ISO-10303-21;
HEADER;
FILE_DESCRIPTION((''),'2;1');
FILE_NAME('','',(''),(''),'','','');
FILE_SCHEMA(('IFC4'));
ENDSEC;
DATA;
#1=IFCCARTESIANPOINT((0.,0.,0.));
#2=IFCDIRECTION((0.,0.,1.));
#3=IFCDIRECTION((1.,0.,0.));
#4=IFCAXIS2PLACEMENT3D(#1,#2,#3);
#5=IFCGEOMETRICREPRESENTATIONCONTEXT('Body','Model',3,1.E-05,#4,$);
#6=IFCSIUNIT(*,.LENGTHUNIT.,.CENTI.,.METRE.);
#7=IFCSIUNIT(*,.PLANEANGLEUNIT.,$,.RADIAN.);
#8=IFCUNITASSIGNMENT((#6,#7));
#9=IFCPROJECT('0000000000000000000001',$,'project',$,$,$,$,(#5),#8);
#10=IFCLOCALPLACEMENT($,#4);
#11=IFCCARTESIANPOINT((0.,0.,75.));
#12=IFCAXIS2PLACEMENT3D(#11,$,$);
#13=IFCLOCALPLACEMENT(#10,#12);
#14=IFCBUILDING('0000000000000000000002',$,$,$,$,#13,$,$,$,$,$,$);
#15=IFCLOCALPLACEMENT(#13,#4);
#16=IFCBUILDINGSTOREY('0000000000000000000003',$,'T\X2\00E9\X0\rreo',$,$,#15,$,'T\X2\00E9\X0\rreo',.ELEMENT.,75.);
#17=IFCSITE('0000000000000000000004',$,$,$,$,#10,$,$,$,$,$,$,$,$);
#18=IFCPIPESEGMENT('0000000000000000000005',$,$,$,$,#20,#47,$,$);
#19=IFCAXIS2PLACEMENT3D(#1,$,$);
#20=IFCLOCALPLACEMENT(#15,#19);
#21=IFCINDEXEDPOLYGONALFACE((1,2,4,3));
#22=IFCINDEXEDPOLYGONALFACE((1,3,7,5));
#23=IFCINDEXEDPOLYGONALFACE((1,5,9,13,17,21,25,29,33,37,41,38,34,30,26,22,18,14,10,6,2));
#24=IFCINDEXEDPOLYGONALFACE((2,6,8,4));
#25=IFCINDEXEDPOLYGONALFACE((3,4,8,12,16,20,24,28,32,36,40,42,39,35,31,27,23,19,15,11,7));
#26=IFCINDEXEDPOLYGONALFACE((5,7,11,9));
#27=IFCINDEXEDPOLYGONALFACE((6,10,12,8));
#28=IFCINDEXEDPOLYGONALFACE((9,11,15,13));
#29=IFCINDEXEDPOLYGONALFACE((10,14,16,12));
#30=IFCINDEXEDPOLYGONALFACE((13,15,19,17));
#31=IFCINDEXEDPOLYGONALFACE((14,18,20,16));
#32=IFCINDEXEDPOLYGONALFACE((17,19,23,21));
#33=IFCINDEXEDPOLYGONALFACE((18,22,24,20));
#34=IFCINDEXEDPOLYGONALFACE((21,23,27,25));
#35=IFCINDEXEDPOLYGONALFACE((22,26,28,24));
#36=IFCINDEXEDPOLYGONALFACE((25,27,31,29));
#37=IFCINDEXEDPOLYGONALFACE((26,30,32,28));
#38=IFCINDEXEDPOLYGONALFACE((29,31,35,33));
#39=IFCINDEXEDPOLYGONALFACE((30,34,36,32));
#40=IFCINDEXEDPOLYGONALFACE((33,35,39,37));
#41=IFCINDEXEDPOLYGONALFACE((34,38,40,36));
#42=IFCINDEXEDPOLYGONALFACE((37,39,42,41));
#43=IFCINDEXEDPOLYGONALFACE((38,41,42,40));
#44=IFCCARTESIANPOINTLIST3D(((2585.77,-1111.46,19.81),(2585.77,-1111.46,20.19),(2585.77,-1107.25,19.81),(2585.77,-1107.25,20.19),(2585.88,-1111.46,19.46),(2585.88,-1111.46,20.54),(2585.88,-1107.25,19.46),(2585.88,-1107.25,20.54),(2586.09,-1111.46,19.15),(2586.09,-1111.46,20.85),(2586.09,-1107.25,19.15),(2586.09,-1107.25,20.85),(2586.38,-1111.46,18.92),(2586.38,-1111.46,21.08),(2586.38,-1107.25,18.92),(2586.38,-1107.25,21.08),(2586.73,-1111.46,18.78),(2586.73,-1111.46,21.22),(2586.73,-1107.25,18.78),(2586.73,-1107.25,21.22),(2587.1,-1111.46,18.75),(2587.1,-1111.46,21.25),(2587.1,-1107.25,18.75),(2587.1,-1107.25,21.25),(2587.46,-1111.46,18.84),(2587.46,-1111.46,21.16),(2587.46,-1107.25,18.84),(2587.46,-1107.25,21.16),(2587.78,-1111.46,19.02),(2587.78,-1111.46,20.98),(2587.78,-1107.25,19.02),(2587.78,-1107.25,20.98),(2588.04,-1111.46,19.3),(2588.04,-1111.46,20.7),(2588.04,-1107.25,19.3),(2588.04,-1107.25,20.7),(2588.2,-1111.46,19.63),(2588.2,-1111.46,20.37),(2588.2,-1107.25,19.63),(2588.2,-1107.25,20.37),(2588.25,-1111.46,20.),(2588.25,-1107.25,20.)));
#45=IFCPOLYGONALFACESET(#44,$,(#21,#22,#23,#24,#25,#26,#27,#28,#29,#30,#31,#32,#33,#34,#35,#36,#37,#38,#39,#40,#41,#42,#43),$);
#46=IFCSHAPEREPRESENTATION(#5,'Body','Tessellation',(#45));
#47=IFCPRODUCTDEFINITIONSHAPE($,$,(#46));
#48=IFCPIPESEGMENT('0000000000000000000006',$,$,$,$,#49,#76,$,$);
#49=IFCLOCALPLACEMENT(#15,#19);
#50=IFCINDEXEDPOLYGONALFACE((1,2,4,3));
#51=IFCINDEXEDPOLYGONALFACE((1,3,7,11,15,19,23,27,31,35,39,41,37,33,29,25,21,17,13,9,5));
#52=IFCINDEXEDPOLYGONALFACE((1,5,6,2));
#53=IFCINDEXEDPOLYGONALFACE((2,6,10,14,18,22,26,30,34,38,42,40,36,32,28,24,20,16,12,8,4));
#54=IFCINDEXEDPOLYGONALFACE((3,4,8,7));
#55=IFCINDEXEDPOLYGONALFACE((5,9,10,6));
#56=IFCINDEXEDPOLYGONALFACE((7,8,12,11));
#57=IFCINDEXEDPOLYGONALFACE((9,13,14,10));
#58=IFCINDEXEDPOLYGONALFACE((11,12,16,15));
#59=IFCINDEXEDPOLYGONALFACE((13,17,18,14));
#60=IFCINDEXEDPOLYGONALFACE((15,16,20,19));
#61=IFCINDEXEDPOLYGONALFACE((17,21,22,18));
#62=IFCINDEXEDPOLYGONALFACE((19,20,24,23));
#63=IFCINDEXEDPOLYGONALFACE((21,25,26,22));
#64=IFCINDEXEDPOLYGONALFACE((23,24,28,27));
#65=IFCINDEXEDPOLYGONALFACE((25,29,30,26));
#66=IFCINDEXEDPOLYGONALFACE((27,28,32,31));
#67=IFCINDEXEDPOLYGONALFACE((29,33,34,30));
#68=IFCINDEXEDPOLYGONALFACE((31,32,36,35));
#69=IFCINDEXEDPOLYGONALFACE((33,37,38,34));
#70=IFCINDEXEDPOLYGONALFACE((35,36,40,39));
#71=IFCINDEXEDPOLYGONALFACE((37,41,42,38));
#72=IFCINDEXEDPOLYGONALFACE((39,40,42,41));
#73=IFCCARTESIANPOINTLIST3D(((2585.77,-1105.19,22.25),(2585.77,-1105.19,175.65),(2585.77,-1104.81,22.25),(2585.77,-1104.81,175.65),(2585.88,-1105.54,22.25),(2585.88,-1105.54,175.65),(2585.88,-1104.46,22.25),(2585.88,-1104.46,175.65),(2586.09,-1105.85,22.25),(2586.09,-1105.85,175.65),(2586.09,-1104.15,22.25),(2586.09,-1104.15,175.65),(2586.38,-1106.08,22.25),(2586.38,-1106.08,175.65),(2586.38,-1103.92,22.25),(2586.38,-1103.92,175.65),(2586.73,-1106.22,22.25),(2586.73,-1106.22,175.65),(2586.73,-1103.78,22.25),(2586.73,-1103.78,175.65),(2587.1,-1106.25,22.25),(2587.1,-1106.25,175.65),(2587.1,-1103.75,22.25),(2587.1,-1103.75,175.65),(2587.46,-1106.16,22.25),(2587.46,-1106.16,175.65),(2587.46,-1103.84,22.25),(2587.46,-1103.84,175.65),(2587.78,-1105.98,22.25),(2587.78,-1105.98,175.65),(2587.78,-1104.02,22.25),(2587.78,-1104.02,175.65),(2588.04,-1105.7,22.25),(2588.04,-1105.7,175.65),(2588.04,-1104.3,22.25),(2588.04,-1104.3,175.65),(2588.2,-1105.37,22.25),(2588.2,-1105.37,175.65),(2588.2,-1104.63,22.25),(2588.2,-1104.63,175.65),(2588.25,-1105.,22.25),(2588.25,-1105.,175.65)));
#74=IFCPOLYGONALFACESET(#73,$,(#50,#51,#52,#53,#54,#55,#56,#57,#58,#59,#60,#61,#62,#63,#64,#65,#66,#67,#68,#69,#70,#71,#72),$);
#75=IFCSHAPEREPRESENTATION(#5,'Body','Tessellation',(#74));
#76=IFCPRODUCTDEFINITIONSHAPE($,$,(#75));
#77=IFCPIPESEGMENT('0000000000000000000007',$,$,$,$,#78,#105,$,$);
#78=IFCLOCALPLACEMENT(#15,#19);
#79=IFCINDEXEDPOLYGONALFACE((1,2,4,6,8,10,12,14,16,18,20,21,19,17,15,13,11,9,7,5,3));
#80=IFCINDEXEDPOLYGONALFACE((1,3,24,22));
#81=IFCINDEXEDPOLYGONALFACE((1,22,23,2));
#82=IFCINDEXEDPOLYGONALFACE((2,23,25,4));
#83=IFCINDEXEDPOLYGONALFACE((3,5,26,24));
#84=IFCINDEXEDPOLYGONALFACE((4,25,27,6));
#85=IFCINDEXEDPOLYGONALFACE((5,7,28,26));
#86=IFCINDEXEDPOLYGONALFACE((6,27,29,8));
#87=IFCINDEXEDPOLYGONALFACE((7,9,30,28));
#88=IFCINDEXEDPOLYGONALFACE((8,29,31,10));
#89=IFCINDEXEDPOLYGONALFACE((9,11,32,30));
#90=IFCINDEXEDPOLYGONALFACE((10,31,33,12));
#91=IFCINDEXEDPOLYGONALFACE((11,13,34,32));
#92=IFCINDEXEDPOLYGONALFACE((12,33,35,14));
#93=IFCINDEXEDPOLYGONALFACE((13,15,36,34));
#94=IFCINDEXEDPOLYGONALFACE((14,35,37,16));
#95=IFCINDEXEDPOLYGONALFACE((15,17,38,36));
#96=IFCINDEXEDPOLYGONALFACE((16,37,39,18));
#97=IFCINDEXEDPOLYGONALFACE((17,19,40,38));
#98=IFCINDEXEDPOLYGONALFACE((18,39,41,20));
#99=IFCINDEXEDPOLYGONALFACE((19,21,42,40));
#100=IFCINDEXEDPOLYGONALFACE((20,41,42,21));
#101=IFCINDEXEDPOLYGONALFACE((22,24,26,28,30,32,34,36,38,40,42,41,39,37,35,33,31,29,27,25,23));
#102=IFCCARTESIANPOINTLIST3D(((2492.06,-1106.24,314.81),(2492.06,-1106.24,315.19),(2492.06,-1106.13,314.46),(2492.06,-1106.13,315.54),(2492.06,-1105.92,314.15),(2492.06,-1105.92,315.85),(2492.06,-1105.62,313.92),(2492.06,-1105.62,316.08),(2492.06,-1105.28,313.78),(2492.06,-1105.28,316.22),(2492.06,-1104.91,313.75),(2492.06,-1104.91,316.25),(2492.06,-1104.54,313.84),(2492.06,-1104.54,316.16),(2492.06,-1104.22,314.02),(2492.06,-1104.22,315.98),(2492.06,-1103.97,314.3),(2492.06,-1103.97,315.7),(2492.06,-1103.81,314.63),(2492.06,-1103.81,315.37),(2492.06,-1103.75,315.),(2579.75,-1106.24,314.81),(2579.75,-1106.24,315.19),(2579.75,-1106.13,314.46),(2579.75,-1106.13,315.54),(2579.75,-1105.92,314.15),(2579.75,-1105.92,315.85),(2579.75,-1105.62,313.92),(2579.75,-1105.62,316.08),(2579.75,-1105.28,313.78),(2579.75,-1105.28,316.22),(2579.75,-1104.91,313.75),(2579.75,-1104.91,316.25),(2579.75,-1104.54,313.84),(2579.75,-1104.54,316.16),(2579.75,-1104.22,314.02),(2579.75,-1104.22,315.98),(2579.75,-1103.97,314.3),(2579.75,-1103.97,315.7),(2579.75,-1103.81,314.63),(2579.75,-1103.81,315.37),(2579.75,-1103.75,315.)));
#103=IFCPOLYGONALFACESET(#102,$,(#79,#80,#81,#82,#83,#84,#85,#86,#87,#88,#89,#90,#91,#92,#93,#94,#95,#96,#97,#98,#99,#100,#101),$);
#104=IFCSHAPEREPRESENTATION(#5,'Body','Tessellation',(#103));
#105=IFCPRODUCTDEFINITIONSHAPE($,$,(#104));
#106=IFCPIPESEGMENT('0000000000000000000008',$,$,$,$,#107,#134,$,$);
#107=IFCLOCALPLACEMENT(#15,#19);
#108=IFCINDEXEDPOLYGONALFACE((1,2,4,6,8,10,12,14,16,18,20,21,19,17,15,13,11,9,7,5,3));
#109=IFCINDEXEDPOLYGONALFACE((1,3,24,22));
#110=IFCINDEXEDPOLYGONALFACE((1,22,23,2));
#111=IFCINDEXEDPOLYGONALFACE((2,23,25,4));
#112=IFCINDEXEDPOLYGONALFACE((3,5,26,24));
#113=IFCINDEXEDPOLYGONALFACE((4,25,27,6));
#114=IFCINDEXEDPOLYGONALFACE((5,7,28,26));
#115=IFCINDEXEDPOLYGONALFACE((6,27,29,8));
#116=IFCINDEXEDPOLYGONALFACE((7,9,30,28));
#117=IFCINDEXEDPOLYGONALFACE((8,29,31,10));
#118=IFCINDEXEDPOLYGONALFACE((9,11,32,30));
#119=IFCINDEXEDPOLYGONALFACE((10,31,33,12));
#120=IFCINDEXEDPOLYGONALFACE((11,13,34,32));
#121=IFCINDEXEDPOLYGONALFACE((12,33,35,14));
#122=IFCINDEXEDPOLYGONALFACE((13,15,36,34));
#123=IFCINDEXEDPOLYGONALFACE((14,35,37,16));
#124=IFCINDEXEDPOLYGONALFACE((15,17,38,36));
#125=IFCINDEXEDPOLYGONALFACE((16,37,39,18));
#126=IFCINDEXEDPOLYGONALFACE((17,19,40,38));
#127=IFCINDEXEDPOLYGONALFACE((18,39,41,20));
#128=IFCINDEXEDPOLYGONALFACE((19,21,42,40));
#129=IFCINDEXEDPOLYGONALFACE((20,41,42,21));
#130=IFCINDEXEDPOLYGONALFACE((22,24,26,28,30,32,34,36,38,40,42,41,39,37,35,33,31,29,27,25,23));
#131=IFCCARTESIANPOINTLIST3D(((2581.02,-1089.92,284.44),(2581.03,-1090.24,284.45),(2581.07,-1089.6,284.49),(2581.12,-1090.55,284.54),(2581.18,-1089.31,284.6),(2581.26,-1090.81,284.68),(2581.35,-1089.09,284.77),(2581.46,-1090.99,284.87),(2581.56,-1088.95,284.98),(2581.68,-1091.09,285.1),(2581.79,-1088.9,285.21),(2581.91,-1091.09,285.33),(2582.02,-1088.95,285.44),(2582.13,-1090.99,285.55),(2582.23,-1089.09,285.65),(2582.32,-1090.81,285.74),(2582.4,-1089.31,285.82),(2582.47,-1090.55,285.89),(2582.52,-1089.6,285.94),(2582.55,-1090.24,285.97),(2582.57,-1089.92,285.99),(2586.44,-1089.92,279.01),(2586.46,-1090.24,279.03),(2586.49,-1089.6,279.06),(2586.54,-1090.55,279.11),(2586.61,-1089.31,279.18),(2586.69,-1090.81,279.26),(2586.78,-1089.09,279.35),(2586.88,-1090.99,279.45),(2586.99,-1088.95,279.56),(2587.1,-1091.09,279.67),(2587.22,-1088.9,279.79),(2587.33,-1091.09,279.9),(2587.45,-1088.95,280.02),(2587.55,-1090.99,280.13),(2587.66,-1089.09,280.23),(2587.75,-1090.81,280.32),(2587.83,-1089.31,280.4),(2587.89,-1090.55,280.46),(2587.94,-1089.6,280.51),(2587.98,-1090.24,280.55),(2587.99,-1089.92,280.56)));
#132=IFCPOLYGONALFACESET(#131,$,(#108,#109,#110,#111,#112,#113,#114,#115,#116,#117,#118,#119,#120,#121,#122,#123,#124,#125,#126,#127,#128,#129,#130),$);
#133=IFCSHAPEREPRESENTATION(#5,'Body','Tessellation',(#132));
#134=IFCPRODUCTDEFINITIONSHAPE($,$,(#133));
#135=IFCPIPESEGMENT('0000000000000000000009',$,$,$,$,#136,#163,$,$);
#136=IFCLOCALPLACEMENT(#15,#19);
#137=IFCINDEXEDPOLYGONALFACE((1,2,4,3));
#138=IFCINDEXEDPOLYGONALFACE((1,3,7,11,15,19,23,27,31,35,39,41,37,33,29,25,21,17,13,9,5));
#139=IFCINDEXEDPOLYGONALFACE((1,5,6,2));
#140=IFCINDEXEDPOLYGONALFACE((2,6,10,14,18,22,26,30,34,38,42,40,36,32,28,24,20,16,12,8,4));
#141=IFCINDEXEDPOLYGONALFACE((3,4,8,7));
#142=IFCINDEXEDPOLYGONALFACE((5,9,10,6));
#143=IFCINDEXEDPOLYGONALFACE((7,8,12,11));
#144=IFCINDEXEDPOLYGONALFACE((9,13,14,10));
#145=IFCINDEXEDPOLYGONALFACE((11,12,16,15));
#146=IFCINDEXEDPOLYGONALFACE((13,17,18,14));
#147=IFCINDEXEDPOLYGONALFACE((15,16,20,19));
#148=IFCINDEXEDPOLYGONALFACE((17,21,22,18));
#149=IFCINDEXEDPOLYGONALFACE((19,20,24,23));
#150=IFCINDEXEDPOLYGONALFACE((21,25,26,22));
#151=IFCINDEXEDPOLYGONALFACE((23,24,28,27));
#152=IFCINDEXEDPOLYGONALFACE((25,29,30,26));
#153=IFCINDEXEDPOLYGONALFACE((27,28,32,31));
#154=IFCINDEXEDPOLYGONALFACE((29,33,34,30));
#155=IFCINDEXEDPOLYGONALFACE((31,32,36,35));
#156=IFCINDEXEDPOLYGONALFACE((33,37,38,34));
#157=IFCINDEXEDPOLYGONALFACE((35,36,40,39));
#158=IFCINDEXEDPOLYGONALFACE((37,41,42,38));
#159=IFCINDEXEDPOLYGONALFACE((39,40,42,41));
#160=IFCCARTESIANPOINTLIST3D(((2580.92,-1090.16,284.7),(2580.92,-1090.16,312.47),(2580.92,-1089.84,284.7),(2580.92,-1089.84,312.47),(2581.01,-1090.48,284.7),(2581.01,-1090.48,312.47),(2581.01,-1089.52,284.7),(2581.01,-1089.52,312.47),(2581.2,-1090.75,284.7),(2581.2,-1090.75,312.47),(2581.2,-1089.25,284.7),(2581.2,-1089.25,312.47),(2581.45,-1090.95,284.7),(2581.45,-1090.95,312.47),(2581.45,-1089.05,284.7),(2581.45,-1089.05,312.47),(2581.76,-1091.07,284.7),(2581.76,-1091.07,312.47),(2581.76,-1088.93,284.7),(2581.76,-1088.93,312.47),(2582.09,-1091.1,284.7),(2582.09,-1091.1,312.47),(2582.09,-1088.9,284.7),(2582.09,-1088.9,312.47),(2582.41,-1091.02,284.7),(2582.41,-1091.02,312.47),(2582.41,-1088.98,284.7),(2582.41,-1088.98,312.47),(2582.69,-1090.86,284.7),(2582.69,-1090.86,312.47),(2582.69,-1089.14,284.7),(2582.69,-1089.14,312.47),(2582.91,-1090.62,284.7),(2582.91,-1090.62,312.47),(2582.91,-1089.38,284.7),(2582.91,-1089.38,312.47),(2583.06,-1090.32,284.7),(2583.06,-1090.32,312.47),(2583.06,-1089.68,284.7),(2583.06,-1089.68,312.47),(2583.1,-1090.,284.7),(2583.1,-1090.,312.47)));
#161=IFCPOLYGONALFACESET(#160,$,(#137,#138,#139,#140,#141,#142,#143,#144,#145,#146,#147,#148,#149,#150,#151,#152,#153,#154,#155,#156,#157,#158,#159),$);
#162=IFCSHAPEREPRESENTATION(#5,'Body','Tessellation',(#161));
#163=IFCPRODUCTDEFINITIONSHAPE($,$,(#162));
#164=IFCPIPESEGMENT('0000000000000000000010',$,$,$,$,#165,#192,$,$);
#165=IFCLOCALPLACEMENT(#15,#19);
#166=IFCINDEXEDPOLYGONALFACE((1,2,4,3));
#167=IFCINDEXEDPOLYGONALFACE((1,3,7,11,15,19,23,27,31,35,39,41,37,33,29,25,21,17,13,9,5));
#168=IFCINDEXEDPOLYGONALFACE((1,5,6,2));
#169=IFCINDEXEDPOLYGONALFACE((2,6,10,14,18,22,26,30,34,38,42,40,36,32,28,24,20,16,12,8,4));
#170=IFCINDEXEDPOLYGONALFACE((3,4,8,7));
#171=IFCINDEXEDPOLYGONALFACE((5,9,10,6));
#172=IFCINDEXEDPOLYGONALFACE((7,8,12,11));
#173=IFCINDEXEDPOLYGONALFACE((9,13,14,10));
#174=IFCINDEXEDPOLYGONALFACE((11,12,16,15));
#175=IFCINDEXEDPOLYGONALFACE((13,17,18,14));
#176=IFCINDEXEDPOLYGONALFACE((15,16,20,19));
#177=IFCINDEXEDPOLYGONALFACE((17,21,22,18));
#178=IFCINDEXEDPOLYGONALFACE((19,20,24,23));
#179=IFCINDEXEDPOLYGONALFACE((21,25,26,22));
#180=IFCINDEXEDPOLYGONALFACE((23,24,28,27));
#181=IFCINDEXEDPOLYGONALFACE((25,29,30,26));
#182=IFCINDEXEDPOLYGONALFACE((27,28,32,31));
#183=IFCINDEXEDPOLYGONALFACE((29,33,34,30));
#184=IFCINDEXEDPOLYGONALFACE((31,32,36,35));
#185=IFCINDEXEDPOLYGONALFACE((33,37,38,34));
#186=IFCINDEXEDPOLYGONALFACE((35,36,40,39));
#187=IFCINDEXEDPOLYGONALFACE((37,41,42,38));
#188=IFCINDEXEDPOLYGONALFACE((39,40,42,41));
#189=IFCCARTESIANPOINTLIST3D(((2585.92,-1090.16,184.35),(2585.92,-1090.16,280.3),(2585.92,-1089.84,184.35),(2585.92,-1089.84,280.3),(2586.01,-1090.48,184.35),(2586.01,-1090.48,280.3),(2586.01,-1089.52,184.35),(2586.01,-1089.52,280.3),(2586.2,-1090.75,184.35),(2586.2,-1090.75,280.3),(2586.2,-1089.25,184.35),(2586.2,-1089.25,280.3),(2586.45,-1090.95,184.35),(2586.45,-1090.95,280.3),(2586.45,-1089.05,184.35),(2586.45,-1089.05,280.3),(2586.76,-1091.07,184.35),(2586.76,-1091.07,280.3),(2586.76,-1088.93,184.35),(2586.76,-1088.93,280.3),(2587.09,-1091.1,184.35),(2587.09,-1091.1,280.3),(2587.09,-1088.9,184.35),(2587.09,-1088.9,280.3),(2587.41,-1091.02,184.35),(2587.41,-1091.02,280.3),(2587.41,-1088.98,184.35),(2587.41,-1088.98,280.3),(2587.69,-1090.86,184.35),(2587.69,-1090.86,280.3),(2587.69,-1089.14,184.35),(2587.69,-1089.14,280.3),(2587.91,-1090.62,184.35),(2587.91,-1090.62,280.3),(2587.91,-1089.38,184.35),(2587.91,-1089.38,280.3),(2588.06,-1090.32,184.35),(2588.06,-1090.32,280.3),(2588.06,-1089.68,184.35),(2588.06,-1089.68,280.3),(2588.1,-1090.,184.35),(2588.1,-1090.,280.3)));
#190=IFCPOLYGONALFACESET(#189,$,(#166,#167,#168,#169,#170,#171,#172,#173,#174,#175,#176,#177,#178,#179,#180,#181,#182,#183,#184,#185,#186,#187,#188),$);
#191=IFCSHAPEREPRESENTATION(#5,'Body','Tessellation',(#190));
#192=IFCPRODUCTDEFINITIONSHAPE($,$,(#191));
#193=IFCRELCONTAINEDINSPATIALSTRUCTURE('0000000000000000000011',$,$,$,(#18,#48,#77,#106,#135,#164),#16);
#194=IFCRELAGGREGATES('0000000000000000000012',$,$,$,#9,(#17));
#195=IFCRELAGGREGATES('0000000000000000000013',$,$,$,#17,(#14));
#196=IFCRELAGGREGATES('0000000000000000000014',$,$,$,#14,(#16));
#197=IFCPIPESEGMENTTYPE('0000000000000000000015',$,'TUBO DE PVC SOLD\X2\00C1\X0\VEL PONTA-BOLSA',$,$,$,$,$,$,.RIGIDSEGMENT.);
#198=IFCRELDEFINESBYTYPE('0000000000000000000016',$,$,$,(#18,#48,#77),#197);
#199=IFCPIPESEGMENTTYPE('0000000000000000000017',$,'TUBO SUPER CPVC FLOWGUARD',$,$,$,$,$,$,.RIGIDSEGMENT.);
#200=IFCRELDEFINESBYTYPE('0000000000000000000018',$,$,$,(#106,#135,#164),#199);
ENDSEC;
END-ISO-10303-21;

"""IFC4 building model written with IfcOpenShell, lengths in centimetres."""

from ifc_helpers import new_model, si_unit, frame, origin_with_axes, origin_2d_with_axis, place, context, project, spatial, circle, extrude, type_object, element, save


model = new_model("IFC4")

# Units and contexts
model_context = context("Model", 3, precision=1e-05, world=origin_with_axes(), identifier="Body")
ifc_project = project(units=[si_unit("LENGTHUNIT", "METRE", prefix="CENTI"), si_unit("PLANEANGLEUNIT", "RADIAN")], contexts=[model_context])

# Site, building, storey
site_placement = place(None, origin_with_axes())
site = spatial("IfcSite", under=ifc_project, at=site_placement)
building_placement = place(site_placement, frame((0.0, 0.0, 75.0)))
building = spatial("IfcBuilding", under=site, at=building_placement)
storey_placement = place(building_placement, origin_with_axes())
storey = spatial("IfcBuildingStorey", under=building, at=storey_placement, Name="Térreo", LongName="Térreo", CompositionType="ELEMENT", Elevation=75.0)

# Pipe segments
pipe_segment_type_1 = type_object("IfcPipeSegmentType", Name="TUBO DE PVC SOLDÁVEL PONTA-BOLSA", PredefinedType="RIGIDSEGMENT")
pipe_segment_1_placement = place(storey_placement, frame((2587.0, -1109.35, 21.25), z_axis=(0.0, 0.0, 1.0), x_axis=(1.0, 0.0, 0.0)))
element("IfcPipeSegment", 1, at=pipe_segment_1_placement, inside=storey, type_object=pipe_segment_type_1, context=model_context, shape_type="SolidModel", body=[
    extrude(circle(Radius=1.25, at=origin_2d_with_axis()), frame((0.0, 2.1, -1.25), z_axis=(0.0, -1.0, 0.0), x_axis=(1.0, 0.0, 0.0)), (0.0, 0.0, 1.0), 4.21),
])
pipe_segment_2_placement = place(storey_placement, frame((2587.0, -1105.0, 175.65), z_axis=(0.0, 0.0, 1.0), x_axis=(1.0, 0.0, 0.0)))
element("IfcPipeSegment", 2, at=pipe_segment_2_placement, inside=storey, type_object=pipe_segment_type_1, context=model_context, shape_type="SolidModel", body=[
    extrude(circle(Radius=1.25, at=origin_2d_with_axis()), frame((0.0, 0.0, 0.0), z_axis=(0.0, 0.0, -1.0), x_axis=(1.0, 0.0, 0.0)), (0.0, 0.0, 1.0), 153.4),
])
pipe_segment_3_placement = place(storey_placement, frame((2535.91, -1105.0, 316.25), z_axis=(0.0, 0.0, 1.0), x_axis=(1.0, 0.0, 0.0)))
element("IfcPipeSegment", 3, at=pipe_segment_3_placement, inside=storey, type_object=pipe_segment_type_1, context=model_context, shape_type="SolidModel", body=[
    extrude(circle(Radius=1.25, at=origin_2d_with_axis()), frame((-43.85, 0.0, -1.25), z_axis=(1.0, 0.0, 0.0), x_axis=(0.0, 1.0, 0.0)), (0.0, 0.0, 1.0), 87.7),
])
pipe_segment_type_2 = type_object("IfcPipeSegmentType", Name="TUBO SUPER CPVC FLOWGUARD", PredefinedType="RIGIDSEGMENT")
pipe_segment_4_placement = place(storey_placement, frame((2584.5, -1090.0, 285.99), z_axis=(0.0, 0.0, 1.0), x_axis=(1.0, 0.0, 0.0)))
element("IfcPipeSegment", 4, at=pipe_segment_4_placement, inside=storey, type_object=pipe_segment_type_2, context=model_context, shape_type="SolidModel", body=[
    extrude(circle(Radius=1.1, at=origin_2d_with_axis()), frame((-2.71, 0.0, -0.78), z_axis=(0.707107, 0.0, -0.707107), x_axis=(0.0, 1.0, 0.0)), (0.0, 0.0, 1.0), 7.67),
])
pipe_segment_5_placement = place(storey_placement, frame((2582.0, -1090.0, 312.47), z_axis=(0.0, 0.0, 1.0), x_axis=(1.0, 0.0, 0.0)))
element("IfcPipeSegment", 5, at=pipe_segment_5_placement, inside=storey, type_object=pipe_segment_type_2, context=model_context, shape_type="SolidModel", body=[
    extrude(circle(Radius=1.1, at=origin_2d_with_axis()), frame((0.0, 0.0, 0.0), z_axis=(0.0, 0.0, -1.0), x_axis=(1.0, 0.0, 0.0)), (0.0, 0.0, 1.0), 27.77),
])
pipe_segment_6_placement = place(storey_placement, frame((2587.0, -1090.0, 280.3), z_axis=(0.0, 0.0, 1.0), x_axis=(1.0, 0.0, 0.0)))
element("IfcPipeSegment", 6, at=pipe_segment_6_placement, inside=storey, type_object=pipe_segment_type_2, context=model_context, shape_type="SolidModel", body=[
    extrude(circle(Radius=1.1, at=origin_2d_with_axis()), frame((0.0, 0.0, 0.0), z_axis=(0.0, 0.0, -1.0), x_axis=(1.0, 0.0, 0.0)), (0.0, 0.0, 1.0), 95.95),
])

save(model, "model.ifc")
